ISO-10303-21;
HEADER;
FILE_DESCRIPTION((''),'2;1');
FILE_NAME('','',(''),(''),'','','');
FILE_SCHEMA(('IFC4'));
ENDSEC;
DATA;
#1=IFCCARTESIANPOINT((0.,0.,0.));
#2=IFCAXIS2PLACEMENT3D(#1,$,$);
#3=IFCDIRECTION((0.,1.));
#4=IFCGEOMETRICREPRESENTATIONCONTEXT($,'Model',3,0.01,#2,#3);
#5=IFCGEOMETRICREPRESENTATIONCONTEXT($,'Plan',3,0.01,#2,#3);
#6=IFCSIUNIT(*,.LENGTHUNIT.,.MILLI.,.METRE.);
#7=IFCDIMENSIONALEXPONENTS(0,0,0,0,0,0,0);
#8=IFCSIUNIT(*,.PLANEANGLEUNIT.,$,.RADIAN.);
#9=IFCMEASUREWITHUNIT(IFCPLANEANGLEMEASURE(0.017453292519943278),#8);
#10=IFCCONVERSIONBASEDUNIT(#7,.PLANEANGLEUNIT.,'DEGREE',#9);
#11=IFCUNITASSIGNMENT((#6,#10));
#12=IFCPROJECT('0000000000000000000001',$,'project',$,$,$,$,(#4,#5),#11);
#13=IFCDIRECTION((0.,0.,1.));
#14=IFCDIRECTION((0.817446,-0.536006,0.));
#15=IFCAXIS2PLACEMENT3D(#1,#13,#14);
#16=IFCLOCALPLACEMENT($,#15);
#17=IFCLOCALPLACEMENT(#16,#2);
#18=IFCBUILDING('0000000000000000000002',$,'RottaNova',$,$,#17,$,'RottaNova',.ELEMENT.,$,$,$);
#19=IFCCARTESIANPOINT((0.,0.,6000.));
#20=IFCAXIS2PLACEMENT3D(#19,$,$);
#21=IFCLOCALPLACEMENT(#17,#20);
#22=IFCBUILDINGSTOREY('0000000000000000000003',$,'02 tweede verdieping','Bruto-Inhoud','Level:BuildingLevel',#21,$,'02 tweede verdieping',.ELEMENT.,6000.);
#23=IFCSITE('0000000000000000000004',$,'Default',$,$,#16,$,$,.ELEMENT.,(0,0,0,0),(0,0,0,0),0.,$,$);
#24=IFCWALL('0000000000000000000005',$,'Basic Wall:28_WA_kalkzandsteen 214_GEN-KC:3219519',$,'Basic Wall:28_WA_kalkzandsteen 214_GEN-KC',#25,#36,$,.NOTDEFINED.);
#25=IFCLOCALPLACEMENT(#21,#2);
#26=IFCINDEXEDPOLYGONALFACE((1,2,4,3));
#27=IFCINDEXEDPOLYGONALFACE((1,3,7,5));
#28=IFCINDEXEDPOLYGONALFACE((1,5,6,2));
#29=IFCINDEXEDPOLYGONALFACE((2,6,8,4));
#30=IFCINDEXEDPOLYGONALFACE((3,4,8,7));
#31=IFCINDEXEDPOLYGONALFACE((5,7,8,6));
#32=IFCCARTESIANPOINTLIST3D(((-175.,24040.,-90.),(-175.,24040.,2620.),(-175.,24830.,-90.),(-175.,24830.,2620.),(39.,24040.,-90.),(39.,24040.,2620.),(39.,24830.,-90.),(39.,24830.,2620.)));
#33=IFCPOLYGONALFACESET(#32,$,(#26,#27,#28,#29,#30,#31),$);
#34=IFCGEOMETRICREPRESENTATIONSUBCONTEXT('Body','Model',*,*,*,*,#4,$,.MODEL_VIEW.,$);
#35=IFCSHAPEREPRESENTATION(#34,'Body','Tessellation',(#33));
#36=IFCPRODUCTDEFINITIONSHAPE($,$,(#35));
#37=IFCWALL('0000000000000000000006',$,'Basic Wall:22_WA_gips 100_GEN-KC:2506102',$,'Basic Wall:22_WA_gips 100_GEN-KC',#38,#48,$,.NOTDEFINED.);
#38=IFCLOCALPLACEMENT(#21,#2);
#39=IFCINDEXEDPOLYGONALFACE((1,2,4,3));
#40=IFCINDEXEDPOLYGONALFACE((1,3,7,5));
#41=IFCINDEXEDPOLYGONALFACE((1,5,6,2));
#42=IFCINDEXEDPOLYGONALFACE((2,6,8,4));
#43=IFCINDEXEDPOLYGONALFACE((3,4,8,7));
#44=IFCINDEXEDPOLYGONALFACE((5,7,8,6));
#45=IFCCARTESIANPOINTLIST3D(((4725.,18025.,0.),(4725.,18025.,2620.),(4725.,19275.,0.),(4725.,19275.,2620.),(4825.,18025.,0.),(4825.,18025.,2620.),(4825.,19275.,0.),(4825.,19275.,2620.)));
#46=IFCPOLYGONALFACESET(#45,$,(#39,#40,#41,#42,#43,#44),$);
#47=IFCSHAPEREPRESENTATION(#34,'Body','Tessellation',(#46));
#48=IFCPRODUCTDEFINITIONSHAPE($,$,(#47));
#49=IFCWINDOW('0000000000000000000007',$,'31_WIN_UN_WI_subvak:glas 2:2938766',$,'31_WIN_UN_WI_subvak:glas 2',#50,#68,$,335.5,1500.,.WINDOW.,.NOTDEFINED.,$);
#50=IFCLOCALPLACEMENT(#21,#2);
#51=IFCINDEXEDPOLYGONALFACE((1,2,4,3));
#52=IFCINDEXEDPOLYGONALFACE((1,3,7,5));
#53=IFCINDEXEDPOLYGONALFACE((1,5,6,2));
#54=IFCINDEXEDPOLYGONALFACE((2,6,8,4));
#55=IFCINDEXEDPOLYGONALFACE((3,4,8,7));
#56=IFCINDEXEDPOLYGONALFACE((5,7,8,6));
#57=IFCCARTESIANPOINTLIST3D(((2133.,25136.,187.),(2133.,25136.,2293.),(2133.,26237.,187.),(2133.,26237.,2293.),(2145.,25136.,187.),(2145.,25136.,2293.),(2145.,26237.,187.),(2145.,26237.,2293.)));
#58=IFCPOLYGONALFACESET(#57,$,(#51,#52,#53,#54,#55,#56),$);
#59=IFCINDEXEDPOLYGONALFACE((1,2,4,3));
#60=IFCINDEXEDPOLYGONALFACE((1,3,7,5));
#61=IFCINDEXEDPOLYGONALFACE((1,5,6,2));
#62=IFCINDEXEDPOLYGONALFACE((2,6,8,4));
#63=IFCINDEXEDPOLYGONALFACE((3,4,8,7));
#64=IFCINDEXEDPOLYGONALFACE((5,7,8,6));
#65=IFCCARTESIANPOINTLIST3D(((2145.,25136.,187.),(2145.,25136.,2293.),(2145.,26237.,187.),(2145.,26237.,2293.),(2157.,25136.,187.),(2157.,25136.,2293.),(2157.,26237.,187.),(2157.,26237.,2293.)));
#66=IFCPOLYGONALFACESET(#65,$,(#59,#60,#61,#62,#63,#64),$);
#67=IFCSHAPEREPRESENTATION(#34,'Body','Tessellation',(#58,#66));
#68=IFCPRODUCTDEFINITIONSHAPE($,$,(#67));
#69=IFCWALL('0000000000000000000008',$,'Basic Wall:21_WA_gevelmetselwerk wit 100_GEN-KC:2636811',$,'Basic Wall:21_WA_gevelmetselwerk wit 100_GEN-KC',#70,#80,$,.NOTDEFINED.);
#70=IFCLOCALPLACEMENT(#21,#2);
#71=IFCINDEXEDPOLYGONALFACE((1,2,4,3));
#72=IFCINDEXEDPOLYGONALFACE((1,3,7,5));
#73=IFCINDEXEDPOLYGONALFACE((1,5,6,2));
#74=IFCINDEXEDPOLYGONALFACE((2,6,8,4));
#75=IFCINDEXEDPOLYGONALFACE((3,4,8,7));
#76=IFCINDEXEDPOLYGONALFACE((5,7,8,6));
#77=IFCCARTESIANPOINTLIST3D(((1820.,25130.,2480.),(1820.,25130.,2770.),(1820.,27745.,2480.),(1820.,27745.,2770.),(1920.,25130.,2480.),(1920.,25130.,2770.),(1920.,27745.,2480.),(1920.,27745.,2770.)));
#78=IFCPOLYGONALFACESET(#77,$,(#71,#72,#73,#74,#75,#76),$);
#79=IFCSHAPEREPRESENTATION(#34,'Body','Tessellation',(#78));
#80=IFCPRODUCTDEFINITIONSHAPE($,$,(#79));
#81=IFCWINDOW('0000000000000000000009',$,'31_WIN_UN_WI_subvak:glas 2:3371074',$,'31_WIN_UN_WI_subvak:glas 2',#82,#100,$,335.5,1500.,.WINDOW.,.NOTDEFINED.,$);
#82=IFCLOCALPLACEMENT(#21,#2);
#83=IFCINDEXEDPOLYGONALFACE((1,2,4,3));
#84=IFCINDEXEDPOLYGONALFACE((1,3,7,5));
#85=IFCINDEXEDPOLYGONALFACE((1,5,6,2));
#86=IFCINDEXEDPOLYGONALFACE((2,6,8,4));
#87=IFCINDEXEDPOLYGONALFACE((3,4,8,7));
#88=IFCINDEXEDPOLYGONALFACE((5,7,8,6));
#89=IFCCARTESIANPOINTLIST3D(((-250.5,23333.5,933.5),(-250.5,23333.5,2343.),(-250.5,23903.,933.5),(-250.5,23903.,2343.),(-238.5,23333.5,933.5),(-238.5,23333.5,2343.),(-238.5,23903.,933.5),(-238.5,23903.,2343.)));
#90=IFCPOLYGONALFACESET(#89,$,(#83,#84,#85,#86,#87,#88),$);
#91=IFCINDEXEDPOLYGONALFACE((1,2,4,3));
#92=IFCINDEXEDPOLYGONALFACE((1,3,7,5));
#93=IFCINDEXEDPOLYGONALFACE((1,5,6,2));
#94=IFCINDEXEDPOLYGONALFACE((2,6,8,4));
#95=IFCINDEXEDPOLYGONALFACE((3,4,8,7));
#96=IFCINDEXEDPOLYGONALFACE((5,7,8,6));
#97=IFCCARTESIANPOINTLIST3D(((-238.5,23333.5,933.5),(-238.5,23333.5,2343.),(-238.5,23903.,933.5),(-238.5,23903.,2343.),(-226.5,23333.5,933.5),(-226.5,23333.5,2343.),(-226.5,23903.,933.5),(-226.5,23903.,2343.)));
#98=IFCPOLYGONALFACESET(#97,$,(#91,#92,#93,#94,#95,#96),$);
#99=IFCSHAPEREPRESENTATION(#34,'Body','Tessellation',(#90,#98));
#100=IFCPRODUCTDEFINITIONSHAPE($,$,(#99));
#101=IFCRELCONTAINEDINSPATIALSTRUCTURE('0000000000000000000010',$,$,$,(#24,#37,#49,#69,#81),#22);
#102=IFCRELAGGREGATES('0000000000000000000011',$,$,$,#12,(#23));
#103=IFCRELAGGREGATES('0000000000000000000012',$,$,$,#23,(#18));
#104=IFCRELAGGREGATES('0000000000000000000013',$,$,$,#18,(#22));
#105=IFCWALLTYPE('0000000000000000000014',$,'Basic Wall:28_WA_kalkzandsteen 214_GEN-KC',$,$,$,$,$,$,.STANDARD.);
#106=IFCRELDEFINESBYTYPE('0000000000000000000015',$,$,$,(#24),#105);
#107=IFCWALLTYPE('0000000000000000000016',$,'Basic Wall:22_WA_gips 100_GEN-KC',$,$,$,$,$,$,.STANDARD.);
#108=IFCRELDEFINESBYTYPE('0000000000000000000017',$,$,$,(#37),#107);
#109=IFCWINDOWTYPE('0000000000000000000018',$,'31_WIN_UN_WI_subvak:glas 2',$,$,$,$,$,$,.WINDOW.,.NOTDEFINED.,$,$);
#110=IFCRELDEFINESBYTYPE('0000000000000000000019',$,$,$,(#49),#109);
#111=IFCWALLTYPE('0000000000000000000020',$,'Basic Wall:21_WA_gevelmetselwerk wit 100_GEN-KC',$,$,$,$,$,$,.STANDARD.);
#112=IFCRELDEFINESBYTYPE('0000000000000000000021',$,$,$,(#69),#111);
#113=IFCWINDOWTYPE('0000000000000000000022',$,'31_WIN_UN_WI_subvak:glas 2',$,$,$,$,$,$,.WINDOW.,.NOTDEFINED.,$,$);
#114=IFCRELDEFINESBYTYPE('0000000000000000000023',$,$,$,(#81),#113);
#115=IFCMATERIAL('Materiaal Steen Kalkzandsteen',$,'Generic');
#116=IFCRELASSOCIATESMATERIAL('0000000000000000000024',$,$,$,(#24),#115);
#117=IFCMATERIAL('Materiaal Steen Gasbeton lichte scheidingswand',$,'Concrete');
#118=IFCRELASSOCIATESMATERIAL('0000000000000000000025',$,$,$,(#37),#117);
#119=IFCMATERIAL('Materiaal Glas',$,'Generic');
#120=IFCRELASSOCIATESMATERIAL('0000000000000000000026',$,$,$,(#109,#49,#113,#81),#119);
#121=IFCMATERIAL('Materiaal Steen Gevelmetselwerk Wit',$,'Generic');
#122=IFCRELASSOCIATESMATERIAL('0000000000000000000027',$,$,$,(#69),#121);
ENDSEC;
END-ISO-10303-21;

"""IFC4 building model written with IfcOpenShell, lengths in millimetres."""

from ifc_helpers import new_model, entity, si_unit, converted_unit, direction, frame, origin, place, context, subcontext, project, spatial, indexed_curve, outline, extrude, source, transform, mapped, material, type_object, type_shapes, element, save


model = new_model("IFC4")

# Units and contexts
model_context = context("Model", 3, precision=0.01, world=origin(), true_north=direction((0.0, 1.0)))
plan_context = context("Plan", 3, precision=0.01, world=origin(), true_north=direction((0.0, 1.0)))
body_context = subcontext(model_context, "Body", "Model", "MODEL_VIEW")
ifc_project = project(units=[si_unit("LENGTHUNIT", "METRE", prefix="MILLI"), converted_unit("PLANEANGLEUNIT", "DEGREE", entity("IfcPlaneAngleMeasure", 0.017453292519943278), si_unit("PLANEANGLEUNIT", "RADIAN"), dimensions=[0, 0, 0, 0, 0, 0, 0])], contexts=[model_context, plan_context])

# Site, building, storey
site_placement = place(None, frame((0.0, 0.0, 0.0), z_axis=(0.0, 0.0, 1.0), x_axis=(0.817446, -0.536006, 0.0)))
site = spatial("IfcSite", under=ifc_project, at=site_placement, Name="Default", CompositionType="ELEMENT", RefLatitude=(0, 0, 0, 0), RefLongitude=(0, 0, 0, 0), RefElevation=0.0)
building_placement = place(site_placement, origin())
building = spatial("IfcBuilding", under=site, at=building_placement, Name="RottaNova", LongName="RottaNova", CompositionType="ELEMENT")
storey_placement = place(building_placement, frame((0.0, 0.0, 6000.0)))
storey = spatial("IfcBuildingStorey", under=building, at=storey_placement, Name="02 tweede verdieping", Description="Bruto-Inhoud", ObjectType="Level:BuildingLevel", LongName="02 tweede verdieping", CompositionType="ELEMENT", Elevation=6000.0)

# Shared definitions
ifc_material_1 = material(Name="Materiaal Glas", Category="Generic")

# Walls
ifc_material_2 = material(Name="Materiaal Steen Kalkzandsteen", Category="Generic")
wall_type_1 = type_object("IfcWallType", Name="Basic Wall:28_WA_kalkzandsteen 214_GEN-KC", PredefinedType="STANDARD")
wall_1_placement = place(storey_placement, frame((-68.0, 24040.0, -90.0), z_axis=(0.0, 0.0, 1.0), x_axis=(0.0, 1.0, 0.0)))
element("IfcWall", 1, at=wall_1_placement, inside=storey, type_object=wall_type_1, material=ifc_material_2, Name="Basic Wall:28_WA_kalkzandsteen 214_GEN-KC:3219519", ObjectType="Basic Wall:28_WA_kalkzandsteen 214_GEN-KC", PredefinedType="NOTDEFINED", context=body_context, shape_type="SweptSolid", body=[
    extrude(outline(indexed_curve([(790.0, 107.0), (0.0, 107.0), (0.0, -107.0), (790.0, -107.0), (790.0, 107.0)], self_intersect=False)), origin(), (0.0, 0.0, 1.0), 2710.0),
])
ifc_material_3 = material(Name="Materiaal Steen Gasbeton lichte scheidingswand", Category="Concrete")
wall_type_2 = type_object("IfcWallType", Name="Basic Wall:22_WA_gips 100_GEN-KC", PredefinedType="STANDARD")
wall_2_placement = place(storey_placement, frame((4775.0, 19275.0, 0.0), z_axis=(0.0, 0.0, 1.0), x_axis=(0.0, -1.0, 0.0)))
element("IfcWall", 2, at=wall_2_placement, inside=storey, type_object=wall_type_2, material=ifc_material_3, Name="Basic Wall:22_WA_gips 100_GEN-KC:2506102", ObjectType="Basic Wall:22_WA_gips 100_GEN-KC", PredefinedType="NOTDEFINED", context=body_context, shape_type="SweptSolid", body=[
    extrude(outline(indexed_curve([(1250.0, 50.0), (0.0, 50.0), (0.0, -50.0), (1250.0, -50.0), (1250.0, 50.0)], self_intersect=False)), origin(), (0.0, 0.0, 1.0), 2620.0),
])

# Window
window_type_1 = type_object("IfcWindowType", Name="31_WIN_UN_WI_subvak:glas 2", PartitioningType="NOTDEFINED", PredefinedType="WINDOW", material=ifc_material_1)
shared_shape_1 = source(origin(), body_context, "Body", "SweptSolid", [
    extrude(outline(indexed_curve([(-550.5, -6.0), (550.5, -6.0), (550.5, 6.0), (-550.5, 6.0), (-550.5, -6.0)], self_intersect=False)), frame((0.0, -6.0, 0.0)), (0.0, 0.0, 1.0), 2106.0),
    extrude(outline(indexed_curve([(-550.5, -6.0), (550.5, -6.0), (550.5, 6.0), (-550.5, 6.0), (-550.5, -6.0)], self_intersect=False)), frame((0.0, 6.0, 0.0)), (0.0, 0.0, 1.0), 2106.0),
])
type_shapes(window_type_1, [shared_shape_1])
window_1_placement = place(storey_placement, frame((2145.0, 25686.5, 187.0), z_axis=(0.0, 0.0, 1.0), x_axis=(0.0, -1.0, 0.0)))
element("IfcWindow", 3, at=window_1_placement, inside=storey, type_object=window_type_1, material=ifc_material_1, Name="31_WIN_UN_WI_subvak:glas 2:2938766", ObjectType="31_WIN_UN_WI_subvak:glas 2", OverallHeight=335.5, OverallWidth=1500.0, PartitioningType="NOTDEFINED", PredefinedType="WINDOW", context=body_context, shape_type="MappedRepresentation", body=[
    mapped(shared_shape_1, transform((0.0, 0.0, 0.0), scale=1.0)),
])

# Wall
ifc_material_4 = material(Name="Materiaal Steen Gevelmetselwerk Wit", Category="Generic")
wall_type_3 = type_object("IfcWallType", Name="Basic Wall:21_WA_gevelmetselwerk wit 100_GEN-KC", PredefinedType="STANDARD")
wall_3_placement = place(storey_placement, frame((1870.0, 25130.0, 2480.0), z_axis=(0.0, 0.0, 1.0), x_axis=(0.0, 1.0, 0.0)))
element("IfcWall", 4, at=wall_3_placement, inside=storey, type_object=wall_type_3, material=ifc_material_4, Name="Basic Wall:21_WA_gevelmetselwerk wit 100_GEN-KC:2636811", ObjectType="Basic Wall:21_WA_gevelmetselwerk wit 100_GEN-KC", PredefinedType="NOTDEFINED", context=body_context, shape_type="SweptSolid", body=[
    extrude(outline(indexed_curve([(2615.0, 50.0), (0.0, 50.0), (0.0, -50.0), (2615.0, -50.0), (2615.0, 50.0)], self_intersect=False)), origin(), (0.0, 0.0, 1.0), 290.0),
])

# Window
window_type_2 = type_object("IfcWindowType", Name="31_WIN_UN_WI_subvak:glas 2", PartitioningType="NOTDEFINED", PredefinedType="WINDOW", material=ifc_material_1)
shared_shape_2 = source(origin(), body_context, "Body", "SweptSolid", [
    extrude(outline(indexed_curve([(-284.7, -6.0), (284.7, -6.0), (284.7, 6.0), (-284.7, 6.0), (-284.7, -6.0)], self_intersect=False)), frame((0.0, -6.0, 0.0)), (0.0, 0.0, 1.0), 1409.5),
    extrude(outline(indexed_curve([(-284.8, -6.0), (284.8, -6.0), (284.8, 6.0), (-284.8, 6.0), (-284.8, -6.0)], self_intersect=False)), frame((0.0, 6.0, 0.0)), (0.0, 0.0, 1.0), 1409.5),
])
type_shapes(window_type_2, [shared_shape_2])
window_2_placement = place(storey_placement, frame((-238.5, 23618.2, 933.5), z_axis=(0.0, 0.0, 1.0), x_axis=(0.0, -1.0, 0.0)))
element("IfcWindow", 5, at=window_2_placement, inside=storey, type_object=window_type_2, material=ifc_material_1, Name="31_WIN_UN_WI_subvak:glas 2:3371074", ObjectType="31_WIN_UN_WI_subvak:glas 2", OverallHeight=335.5, OverallWidth=1500.0, PartitioningType="NOTDEFINED", PredefinedType="WINDOW", context=body_context, shape_type="MappedRepresentation", body=[
    mapped(shared_shape_2, transform((0.0, 0.0, 0.0), scale=1.0)),
])

save(model, "model.ifc")
